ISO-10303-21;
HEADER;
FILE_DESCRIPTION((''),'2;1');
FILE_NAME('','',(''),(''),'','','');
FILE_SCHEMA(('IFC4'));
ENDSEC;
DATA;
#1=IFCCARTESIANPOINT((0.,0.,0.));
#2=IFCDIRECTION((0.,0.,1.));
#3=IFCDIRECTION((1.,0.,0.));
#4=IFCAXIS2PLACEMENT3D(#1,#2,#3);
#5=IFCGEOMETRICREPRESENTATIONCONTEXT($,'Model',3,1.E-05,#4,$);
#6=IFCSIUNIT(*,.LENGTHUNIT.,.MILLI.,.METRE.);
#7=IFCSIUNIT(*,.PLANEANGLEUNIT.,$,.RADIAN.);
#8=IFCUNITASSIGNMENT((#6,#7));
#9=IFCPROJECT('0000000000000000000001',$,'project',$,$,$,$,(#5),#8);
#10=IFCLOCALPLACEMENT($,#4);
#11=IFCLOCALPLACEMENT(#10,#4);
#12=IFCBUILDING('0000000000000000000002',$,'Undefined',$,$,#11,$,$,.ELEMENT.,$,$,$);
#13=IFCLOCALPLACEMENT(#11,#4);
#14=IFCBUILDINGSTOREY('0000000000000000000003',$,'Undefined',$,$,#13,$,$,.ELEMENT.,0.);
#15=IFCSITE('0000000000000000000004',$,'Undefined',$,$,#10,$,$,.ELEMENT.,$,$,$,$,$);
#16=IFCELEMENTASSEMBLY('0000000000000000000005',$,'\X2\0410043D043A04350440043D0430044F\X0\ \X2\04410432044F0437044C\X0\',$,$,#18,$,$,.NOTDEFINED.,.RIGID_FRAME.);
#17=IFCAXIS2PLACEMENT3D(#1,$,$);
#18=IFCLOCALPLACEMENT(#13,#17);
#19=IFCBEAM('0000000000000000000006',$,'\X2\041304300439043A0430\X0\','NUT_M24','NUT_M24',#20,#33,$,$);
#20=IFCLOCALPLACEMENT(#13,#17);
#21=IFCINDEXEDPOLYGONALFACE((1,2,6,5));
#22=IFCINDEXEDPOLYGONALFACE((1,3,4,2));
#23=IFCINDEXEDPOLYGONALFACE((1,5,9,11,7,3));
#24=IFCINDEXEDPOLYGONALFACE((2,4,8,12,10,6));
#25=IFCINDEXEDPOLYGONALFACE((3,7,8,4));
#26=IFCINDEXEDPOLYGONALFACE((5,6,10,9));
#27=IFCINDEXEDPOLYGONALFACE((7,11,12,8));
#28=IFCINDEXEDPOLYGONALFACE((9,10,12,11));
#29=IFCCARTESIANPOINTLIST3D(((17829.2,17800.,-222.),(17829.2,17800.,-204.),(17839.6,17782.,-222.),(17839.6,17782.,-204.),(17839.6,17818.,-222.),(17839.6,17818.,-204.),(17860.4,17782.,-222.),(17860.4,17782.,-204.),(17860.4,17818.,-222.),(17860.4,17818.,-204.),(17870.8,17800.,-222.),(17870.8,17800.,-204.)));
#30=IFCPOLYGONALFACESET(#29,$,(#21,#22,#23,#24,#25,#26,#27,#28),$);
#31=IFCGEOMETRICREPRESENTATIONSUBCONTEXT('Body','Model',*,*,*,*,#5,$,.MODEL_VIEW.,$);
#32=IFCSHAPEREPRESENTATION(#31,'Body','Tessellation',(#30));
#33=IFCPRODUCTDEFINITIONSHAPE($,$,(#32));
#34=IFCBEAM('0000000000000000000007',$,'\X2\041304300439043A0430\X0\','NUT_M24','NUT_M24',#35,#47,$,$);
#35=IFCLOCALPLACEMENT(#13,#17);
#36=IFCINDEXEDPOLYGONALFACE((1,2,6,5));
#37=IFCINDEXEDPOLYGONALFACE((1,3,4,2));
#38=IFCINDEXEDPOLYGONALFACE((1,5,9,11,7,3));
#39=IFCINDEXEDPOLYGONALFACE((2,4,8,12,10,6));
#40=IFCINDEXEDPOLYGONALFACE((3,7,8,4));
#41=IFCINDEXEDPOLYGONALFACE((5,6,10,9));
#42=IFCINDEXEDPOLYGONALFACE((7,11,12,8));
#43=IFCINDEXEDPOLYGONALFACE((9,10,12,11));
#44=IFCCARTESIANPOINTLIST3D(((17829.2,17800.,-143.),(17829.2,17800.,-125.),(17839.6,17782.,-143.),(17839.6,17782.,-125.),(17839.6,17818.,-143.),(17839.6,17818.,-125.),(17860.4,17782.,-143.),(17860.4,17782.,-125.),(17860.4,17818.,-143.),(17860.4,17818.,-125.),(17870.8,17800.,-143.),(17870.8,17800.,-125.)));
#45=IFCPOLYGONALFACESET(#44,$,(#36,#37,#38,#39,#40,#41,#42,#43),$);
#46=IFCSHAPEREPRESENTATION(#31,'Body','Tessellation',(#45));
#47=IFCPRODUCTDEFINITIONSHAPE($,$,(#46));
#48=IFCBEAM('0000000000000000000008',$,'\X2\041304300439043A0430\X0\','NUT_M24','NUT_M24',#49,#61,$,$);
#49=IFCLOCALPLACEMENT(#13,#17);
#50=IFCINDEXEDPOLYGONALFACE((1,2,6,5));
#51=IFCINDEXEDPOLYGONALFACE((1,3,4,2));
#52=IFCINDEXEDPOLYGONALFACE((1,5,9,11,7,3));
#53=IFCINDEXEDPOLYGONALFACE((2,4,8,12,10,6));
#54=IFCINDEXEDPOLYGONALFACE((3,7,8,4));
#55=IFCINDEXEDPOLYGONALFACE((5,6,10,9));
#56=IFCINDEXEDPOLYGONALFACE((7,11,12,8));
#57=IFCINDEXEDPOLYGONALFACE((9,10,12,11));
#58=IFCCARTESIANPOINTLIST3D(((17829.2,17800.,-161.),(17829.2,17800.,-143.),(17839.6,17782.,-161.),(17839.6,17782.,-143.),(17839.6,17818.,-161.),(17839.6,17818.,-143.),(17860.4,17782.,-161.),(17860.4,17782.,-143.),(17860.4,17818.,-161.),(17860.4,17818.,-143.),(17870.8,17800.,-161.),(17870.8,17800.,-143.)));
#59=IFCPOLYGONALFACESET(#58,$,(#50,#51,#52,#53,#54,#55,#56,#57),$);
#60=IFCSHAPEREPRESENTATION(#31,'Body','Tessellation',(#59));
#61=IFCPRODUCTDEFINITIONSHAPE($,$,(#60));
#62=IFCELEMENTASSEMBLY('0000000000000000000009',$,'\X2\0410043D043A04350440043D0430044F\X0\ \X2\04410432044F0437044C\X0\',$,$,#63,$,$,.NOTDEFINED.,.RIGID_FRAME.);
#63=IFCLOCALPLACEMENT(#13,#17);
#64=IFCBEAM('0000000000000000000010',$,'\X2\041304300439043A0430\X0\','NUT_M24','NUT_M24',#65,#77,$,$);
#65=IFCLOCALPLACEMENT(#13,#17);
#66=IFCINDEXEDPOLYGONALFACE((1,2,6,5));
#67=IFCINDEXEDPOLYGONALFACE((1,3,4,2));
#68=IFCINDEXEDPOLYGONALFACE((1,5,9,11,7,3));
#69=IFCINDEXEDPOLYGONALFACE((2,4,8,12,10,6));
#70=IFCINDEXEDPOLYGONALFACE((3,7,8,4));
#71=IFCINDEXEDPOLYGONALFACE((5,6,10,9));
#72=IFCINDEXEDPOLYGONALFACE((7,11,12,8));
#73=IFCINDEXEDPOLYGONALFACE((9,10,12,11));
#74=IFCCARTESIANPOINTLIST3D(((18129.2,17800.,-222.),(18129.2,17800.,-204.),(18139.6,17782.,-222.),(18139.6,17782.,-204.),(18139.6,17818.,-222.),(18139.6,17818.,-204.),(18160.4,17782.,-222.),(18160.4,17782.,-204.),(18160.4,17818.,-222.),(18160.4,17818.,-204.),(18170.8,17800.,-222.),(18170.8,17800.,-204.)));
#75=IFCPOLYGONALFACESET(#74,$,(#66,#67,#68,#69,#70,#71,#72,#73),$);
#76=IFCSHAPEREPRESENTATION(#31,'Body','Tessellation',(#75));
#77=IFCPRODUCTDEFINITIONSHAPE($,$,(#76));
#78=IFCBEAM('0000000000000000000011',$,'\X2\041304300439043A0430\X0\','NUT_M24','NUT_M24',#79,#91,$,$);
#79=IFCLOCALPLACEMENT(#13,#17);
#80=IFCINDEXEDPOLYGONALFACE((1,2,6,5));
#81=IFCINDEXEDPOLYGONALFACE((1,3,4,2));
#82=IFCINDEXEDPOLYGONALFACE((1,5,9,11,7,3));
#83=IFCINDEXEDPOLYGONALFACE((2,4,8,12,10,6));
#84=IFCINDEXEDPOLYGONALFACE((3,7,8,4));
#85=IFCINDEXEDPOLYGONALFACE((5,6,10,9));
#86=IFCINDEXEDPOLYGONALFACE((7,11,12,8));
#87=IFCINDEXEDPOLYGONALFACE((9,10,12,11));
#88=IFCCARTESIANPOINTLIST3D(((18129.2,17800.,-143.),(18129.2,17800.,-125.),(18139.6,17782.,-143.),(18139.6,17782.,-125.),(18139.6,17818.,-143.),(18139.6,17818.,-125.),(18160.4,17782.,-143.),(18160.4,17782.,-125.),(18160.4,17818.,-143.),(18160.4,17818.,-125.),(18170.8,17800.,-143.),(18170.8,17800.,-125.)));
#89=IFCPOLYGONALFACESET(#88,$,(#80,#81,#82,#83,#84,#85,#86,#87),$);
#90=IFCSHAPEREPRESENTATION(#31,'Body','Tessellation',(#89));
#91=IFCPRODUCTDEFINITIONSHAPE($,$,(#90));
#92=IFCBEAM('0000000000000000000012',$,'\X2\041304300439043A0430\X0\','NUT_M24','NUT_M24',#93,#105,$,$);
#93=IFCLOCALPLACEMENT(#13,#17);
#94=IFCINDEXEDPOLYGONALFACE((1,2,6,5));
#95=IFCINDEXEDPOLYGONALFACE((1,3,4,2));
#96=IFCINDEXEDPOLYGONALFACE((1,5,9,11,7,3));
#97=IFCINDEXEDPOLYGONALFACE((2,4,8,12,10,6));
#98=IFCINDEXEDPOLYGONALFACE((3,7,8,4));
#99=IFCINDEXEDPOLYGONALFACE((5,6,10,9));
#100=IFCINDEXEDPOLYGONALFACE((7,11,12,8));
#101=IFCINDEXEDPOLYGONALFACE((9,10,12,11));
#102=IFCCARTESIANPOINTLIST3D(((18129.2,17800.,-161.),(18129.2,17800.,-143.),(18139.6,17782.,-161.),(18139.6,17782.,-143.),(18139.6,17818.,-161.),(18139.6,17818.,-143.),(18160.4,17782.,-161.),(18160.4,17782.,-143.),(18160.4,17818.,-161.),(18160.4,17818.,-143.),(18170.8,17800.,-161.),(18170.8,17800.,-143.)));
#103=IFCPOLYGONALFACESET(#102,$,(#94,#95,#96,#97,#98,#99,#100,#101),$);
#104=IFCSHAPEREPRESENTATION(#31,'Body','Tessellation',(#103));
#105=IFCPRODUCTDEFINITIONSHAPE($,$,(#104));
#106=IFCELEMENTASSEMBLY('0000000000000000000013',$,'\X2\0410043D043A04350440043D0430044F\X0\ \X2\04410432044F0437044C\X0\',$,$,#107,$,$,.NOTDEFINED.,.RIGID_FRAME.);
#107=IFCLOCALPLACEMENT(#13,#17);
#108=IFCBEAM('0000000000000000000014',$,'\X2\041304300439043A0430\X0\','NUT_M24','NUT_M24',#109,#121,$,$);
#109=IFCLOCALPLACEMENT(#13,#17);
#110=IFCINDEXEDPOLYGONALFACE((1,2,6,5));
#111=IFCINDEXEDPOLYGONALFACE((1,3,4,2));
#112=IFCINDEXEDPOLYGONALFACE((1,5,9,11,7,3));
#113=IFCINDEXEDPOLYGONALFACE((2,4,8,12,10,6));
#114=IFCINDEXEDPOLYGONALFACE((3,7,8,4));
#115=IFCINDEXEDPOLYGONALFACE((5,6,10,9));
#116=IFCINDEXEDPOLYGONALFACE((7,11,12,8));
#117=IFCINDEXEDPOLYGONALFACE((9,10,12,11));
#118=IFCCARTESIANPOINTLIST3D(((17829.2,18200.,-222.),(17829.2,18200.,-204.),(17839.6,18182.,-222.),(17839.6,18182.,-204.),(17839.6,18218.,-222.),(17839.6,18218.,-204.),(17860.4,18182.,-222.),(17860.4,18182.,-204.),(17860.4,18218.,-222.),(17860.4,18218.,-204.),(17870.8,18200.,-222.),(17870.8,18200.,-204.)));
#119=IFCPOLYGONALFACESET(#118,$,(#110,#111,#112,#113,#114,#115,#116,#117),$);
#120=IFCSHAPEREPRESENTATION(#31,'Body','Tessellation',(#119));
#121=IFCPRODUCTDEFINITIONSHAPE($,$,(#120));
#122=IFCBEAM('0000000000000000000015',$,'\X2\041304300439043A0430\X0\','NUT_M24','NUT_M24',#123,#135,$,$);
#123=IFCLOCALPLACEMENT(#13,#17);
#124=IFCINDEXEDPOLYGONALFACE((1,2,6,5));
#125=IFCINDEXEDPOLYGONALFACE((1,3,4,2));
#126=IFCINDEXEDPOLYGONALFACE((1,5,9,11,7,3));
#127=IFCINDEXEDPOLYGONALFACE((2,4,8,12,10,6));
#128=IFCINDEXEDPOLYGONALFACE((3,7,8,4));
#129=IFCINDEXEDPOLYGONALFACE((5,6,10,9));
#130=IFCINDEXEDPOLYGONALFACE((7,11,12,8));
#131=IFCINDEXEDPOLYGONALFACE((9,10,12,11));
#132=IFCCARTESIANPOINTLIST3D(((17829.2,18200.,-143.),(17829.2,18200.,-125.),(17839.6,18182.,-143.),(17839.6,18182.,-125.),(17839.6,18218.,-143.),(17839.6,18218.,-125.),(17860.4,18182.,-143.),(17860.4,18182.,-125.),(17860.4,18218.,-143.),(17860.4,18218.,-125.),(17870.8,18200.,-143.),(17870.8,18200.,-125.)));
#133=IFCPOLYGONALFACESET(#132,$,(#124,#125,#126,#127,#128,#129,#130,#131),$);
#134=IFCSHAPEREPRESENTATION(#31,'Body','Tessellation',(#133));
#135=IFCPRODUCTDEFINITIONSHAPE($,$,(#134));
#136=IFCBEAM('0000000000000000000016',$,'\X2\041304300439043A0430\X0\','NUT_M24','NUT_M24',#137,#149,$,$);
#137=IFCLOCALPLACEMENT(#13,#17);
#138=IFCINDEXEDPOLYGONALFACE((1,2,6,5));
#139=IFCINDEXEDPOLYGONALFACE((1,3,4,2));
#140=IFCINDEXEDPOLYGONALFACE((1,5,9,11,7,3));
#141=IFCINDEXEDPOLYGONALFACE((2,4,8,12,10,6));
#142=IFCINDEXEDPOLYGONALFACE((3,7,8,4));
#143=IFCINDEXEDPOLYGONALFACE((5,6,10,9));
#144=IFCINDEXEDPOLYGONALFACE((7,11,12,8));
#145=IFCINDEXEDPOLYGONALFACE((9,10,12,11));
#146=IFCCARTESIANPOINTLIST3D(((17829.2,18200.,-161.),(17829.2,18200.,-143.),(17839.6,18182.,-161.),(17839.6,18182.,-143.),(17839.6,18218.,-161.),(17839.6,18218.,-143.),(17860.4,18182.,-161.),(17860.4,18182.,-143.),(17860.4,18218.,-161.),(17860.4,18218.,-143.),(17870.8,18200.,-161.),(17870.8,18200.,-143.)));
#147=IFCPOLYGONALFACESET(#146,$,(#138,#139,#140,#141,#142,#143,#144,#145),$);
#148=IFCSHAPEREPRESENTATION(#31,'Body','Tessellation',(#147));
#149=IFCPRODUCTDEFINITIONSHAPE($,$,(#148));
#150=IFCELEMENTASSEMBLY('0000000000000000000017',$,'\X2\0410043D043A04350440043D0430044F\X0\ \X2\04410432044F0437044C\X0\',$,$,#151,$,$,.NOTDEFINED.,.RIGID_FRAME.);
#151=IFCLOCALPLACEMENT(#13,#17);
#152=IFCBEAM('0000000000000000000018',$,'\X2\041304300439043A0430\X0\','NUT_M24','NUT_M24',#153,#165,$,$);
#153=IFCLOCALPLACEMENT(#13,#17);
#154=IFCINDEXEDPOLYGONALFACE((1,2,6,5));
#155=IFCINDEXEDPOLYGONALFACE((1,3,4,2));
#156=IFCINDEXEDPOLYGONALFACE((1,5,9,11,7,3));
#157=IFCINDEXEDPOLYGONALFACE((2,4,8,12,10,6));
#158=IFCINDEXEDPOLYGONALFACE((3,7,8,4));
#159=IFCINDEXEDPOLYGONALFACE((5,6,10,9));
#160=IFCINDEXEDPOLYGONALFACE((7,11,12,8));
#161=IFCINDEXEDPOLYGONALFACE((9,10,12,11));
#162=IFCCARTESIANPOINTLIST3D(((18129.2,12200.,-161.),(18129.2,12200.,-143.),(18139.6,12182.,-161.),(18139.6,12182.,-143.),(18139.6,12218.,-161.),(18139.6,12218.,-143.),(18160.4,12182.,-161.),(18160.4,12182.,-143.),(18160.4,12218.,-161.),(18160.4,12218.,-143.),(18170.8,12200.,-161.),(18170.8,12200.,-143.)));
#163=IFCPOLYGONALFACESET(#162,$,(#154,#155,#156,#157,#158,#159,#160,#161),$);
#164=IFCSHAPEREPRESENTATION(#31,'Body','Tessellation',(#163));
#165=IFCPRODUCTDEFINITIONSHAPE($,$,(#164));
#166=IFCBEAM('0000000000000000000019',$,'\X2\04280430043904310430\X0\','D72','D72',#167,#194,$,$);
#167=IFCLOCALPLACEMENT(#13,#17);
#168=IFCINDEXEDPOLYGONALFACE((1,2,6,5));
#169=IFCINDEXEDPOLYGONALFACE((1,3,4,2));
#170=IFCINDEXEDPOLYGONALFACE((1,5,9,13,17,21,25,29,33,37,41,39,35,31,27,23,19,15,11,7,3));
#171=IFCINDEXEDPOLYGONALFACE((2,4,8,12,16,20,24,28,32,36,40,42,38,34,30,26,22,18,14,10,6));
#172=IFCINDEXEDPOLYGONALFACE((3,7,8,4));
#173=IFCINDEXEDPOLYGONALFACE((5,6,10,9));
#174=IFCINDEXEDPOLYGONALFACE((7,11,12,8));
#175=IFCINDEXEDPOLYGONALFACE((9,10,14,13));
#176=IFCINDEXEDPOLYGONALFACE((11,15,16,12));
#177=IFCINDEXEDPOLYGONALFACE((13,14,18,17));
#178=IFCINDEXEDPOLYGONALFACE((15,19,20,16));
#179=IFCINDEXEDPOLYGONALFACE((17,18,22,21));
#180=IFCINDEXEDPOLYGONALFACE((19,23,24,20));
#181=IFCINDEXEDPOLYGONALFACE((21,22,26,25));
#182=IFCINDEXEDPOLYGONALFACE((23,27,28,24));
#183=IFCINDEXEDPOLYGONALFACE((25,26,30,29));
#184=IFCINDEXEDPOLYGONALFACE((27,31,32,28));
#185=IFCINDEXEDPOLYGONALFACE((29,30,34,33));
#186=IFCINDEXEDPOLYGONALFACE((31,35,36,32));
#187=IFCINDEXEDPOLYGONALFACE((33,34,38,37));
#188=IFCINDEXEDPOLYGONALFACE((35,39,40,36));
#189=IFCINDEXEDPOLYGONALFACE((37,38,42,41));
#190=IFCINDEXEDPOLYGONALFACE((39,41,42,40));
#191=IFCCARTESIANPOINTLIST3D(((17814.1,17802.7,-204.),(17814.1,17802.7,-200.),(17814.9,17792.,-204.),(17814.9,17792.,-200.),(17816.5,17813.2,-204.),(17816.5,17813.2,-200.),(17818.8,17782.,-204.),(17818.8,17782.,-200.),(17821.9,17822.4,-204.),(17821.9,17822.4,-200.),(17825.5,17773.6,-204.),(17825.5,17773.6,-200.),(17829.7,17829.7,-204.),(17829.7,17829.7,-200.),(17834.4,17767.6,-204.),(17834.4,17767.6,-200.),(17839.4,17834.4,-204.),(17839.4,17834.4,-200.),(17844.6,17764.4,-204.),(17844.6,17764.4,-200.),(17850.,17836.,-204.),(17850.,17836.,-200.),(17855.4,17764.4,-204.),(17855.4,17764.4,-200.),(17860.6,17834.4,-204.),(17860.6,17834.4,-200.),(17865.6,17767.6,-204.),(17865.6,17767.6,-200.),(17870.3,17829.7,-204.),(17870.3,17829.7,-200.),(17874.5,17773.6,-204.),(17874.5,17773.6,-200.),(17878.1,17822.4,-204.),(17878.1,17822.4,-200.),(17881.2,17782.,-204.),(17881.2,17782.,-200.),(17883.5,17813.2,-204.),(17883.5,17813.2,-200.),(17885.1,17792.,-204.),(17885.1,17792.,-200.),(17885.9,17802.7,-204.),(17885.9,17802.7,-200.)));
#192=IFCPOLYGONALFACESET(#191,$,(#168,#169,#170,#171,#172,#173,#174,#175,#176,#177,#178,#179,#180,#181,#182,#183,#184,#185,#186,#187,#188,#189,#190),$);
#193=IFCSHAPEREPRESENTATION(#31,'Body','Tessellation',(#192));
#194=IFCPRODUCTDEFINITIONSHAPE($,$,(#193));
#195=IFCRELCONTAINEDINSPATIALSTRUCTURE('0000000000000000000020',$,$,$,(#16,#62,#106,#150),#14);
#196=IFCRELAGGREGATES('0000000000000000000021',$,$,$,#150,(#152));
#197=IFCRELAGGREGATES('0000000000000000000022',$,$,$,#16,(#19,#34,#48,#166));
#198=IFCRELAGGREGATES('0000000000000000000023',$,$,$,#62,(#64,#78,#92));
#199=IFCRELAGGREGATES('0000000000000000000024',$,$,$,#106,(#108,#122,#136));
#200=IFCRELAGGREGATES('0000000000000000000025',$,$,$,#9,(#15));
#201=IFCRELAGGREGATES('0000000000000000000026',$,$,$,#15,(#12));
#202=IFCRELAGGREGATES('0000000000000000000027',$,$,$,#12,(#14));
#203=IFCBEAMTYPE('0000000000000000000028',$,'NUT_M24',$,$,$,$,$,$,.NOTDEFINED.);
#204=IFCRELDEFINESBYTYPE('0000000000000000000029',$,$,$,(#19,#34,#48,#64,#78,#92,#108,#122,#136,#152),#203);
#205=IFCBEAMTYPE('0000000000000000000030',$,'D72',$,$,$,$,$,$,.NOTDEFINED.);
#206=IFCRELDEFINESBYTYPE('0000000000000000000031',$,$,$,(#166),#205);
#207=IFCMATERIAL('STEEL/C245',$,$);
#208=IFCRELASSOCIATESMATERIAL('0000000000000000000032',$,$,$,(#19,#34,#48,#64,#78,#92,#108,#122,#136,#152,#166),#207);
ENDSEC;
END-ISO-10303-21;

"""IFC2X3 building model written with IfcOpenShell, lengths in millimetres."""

from ifc_helpers import new_model, si_unit, frame, origin_with_axes, origin_2d_with_axis, place, context, subcontext, project, spatial, polyline, circle, outline, extrude, material, type_object, element, aggregate, save


model = new_model("IFC2X3")

# Units and contexts
model_context = context("Model", 3, precision=1e-05, world=origin_with_axes())
body_context = subcontext(model_context, "Body", "Model", "MODEL_VIEW")
ifc_project = project(units=[si_unit("LENGTHUNIT", "METRE", prefix="MILLI"), si_unit("PLANEANGLEUNIT", "RADIAN")], contexts=[model_context])

# Site, building, storey
site_placement = place(None, origin_with_axes())
site = spatial("IfcSite", under=ifc_project, at=site_placement, Name="Undefined", CompositionType="ELEMENT")
building_placement = place(site_placement, origin_with_axes())
building = spatial("IfcBuilding", under=site, at=building_placement, Name="Undefined", CompositionType="ELEMENT")
storey_placement = place(building_placement, origin_with_axes())
storey = spatial("IfcBuildingStorey", under=building, at=storey_placement, Name="Undefined", CompositionType="ELEMENT", Elevation=0.0)

# Element assemblies, beams
assembly_1_placement = place(storey_placement, origin_with_axes())
assembly_1 = element("IfcElementAssembly", 1, at=assembly_1_placement, inside=storey, Name="Анкерная связь", AssemblyPlace="NOTDEFINED", PredefinedType="RIGID_FRAME")
ifc_material_1 = material(Name="STEEL/C245")
beam_type_1 = type_object("IfcBeamType", Name="NUT_M24", PredefinedType="NOTDEFINED")
beam_1_placement = place(assembly_1_placement, frame((17850.0, 17800.0, -204.0), z_axis=(0.0, -1.0, 0.0), x_axis=(0.0, 0.0, -1.0)))
beam_1 = element("IfcBeam", 2, at=beam_1_placement, type_object=beam_type_1, material=ifc_material_1, Name="Гайка", Description="NUT_M24", ObjectType="NUT_M24", context=body_context, shape_type="SweptSolid", body=[
    extrude(outline(polyline([(-10.4, 18.0), (10.4, 18.0), (20.8, 0.0), (10.4, -18.0), (-10.4, -18.0), (-20.8, 0.0), (-10.4, 18.0)])), frame((18.0, 0.0, 0.0), z_axis=(-1.0, 0.0, 0.0), x_axis=(0.0, -1.0, 0.0)), (0.0, 0.0, 1.0), 18.0),
])
beam_2_placement = place(assembly_1_placement, frame((17850.0, 17800.0, -125.0), z_axis=(0.0, -1.0, 0.0), x_axis=(0.0, 0.0, -1.0)))
beam_2 = element("IfcBeam", 3, at=beam_2_placement, type_object=beam_type_1, material=ifc_material_1, Name="Гайка", Description="NUT_M24", ObjectType="NUT_M24", context=body_context, shape_type="SweptSolid", body=[
    extrude(outline(polyline([(-10.4, 18.0), (10.4, 18.0), (20.8, 0.0), (10.4, -18.0), (-10.4, -18.0), (-20.8, 0.0), (-10.4, 18.0)])), frame((18.0, 0.0, 0.0), z_axis=(-1.0, 0.0, 0.0), x_axis=(0.0, -1.0, 0.0)), (0.0, 0.0, 1.0), 18.0),
])
beam_3_placement = place(assembly_1_placement, frame((17850.0, 17800.0, -143.0), z_axis=(0.0, -1.0, 0.0), x_axis=(0.0, 0.0, -1.0)))
beam_3 = element("IfcBeam", 4, at=beam_3_placement, type_object=beam_type_1, material=ifc_material_1, Name="Гайка", Description="NUT_M24", ObjectType="NUT_M24", context=body_context, shape_type="SweptSolid", body=[
    extrude(outline(polyline([(-10.4, 18.0), (10.4, 18.0), (20.8, 0.0), (10.4, -18.0), (-10.4, -18.0), (-20.8, 0.0), (-10.4, 18.0)])), frame((18.0, 0.0, 0.0), z_axis=(-1.0, 0.0, 0.0), x_axis=(0.0, -1.0, 0.0)), (0.0, 0.0, 1.0), 18.0),
])
assembly_2_placement = place(storey_placement, origin_with_axes())
assembly_2 = element("IfcElementAssembly", 5, at=assembly_2_placement, inside=storey, Name="Анкерная связь", AssemblyPlace="NOTDEFINED", PredefinedType="RIGID_FRAME")
beam_4_placement = place(assembly_2_placement, frame((18150.0, 17800.0, -204.0), z_axis=(0.0, 1.0, 0.0), x_axis=(0.0, 0.0, -1.0)))
beam_4 = element("IfcBeam", 6, at=beam_4_placement, type_object=beam_type_1, material=ifc_material_1, Name="Гайка", Description="NUT_M24", ObjectType="NUT_M24", context=body_context, shape_type="SweptSolid", body=[
    extrude(outline(polyline([(-10.4, 18.0), (10.4, 18.0), (20.8, 0.0), (10.4, -18.0), (-10.4, -18.0), (-20.8, 0.0), (-10.4, 18.0)])), frame((18.0, 0.0, 0.0), z_axis=(-1.0, 0.0, 0.0), x_axis=(0.0, -1.0, 0.0)), (0.0, 0.0, 1.0), 18.0),
])
beam_5_placement = place(assembly_2_placement, frame((18150.0, 17800.0, -125.0), z_axis=(0.0, 1.0, 0.0), x_axis=(0.0, 0.0, -1.0)))
beam_5 = element("IfcBeam", 7, at=beam_5_placement, type_object=beam_type_1, material=ifc_material_1, Name="Гайка", Description="NUT_M24", ObjectType="NUT_M24", context=body_context, shape_type="SweptSolid", body=[
    extrude(outline(polyline([(-10.4, 18.0), (10.4, 18.0), (20.8, 0.0), (10.4, -18.0), (-10.4, -18.0), (-20.8, 0.0), (-10.4, 18.0)])), frame((18.0, 0.0, 0.0), z_axis=(-1.0, 0.0, 0.0), x_axis=(0.0, -1.0, 0.0)), (0.0, 0.0, 1.0), 18.0),
])
beam_6_placement = place(assembly_2_placement, frame((18150.0, 17800.0, -143.0), z_axis=(0.0, 1.0, 0.0), x_axis=(0.0, 0.0, -1.0)))
beam_6 = element("IfcBeam", 8, at=beam_6_placement, type_object=beam_type_1, material=ifc_material_1, Name="Гайка", Description="NUT_M24", ObjectType="NUT_M24", context=body_context, shape_type="SweptSolid", body=[
    extrude(outline(polyline([(-10.4, 18.0), (10.4, 18.0), (20.8, 0.0), (10.4, -18.0), (-10.4, -18.0), (-20.8, 0.0), (-10.4, 18.0)])), frame((18.0, 0.0, 0.0), z_axis=(-1.0, 0.0, 0.0), x_axis=(0.0, -1.0, 0.0)), (0.0, 0.0, 1.0), 18.0),
])
assembly_3_placement = place(storey_placement, origin_with_axes())
assembly_3 = element("IfcElementAssembly", 9, at=assembly_3_placement, inside=storey, Name="Анкерная связь", AssemblyPlace="NOTDEFINED", PredefinedType="RIGID_FRAME")
beam_7_placement = place(assembly_3_placement, frame((17850.0, 18200.0, -204.0), z_axis=(0.0, -1.0, 0.0), x_axis=(0.0, 0.0, -1.0)))
beam_7 = element("IfcBeam", 10, at=beam_7_placement, type_object=beam_type_1, material=ifc_material_1, Name="Гайка", Description="NUT_M24", ObjectType="NUT_M24", context=body_context, shape_type="SweptSolid", body=[
    extrude(outline(polyline([(-10.4, 18.0), (10.4, 18.0), (20.8, 0.0), (10.4, -18.0), (-10.4, -18.0), (-20.8, 0.0), (-10.4, 18.0)])), frame((18.0, 0.0, 0.0), z_axis=(-1.0, 0.0, 0.0), x_axis=(0.0, -1.0, 0.0)), (0.0, 0.0, 1.0), 18.0),
])
beam_8_placement = place(assembly_3_placement, frame((17850.0, 18200.0, -125.0), z_axis=(0.0, -1.0, 0.0), x_axis=(0.0, 0.0, -1.0)))
beam_8 = element("IfcBeam", 11, at=beam_8_placement, type_object=beam_type_1, material=ifc_material_1, Name="Гайка", Description="NUT_M24", ObjectType="NUT_M24", context=body_context, shape_type="SweptSolid", body=[
    extrude(outline(polyline([(-10.4, 18.0), (10.4, 18.0), (20.8, 0.0), (10.4, -18.0), (-10.4, -18.0), (-20.8, 0.0), (-10.4, 18.0)])), frame((18.0, 0.0, 0.0), z_axis=(-1.0, 0.0, 0.0), x_axis=(0.0, -1.0, 0.0)), (0.0, 0.0, 1.0), 18.0),
])
beam_9_placement = place(assembly_3_placement, frame((17850.0, 18200.0, -143.0), z_axis=(0.0, -1.0, 0.0), x_axis=(0.0, 0.0, -1.0)))
beam_9 = element("IfcBeam", 12, at=beam_9_placement, type_object=beam_type_1, material=ifc_material_1, Name="Гайка", Description="NUT_M24", ObjectType="NUT_M24", context=body_context, shape_type="SweptSolid", body=[
    extrude(outline(polyline([(-10.4, 18.0), (10.4, 18.0), (20.8, 0.0), (10.4, -18.0), (-10.4, -18.0), (-20.8, 0.0), (-10.4, 18.0)])), frame((18.0, 0.0, 0.0), z_axis=(-1.0, 0.0, 0.0), x_axis=(0.0, -1.0, 0.0)), (0.0, 0.0, 1.0), 18.0),
])

# Element assembly, beam
assembly_4_placement = place(storey_placement, origin_with_axes())
assembly_4 = element("IfcElementAssembly", 13, at=assembly_4_placement, inside=storey, Name="Анкерная связь", AssemblyPlace="NOTDEFINED", PredefinedType="RIGID_FRAME")
beam_10_placement = place(assembly_4_placement, frame((18150.0, 12200.0, -143.0), z_axis=(0.0, 1.0, 0.0), x_axis=(0.0, 0.0, -1.0)))
beam_10 = element("IfcBeam", 14, at=beam_10_placement, type_object=beam_type_1, material=ifc_material_1, Name="Гайка", Description="NUT_M24", ObjectType="NUT_M24", context=body_context, shape_type="SweptSolid", body=[
    extrude(outline(polyline([(-10.4, 18.0), (10.4, 18.0), (20.8, 0.0), (10.4, -18.0), (-10.4, -18.0), (-20.8, 0.0), (-10.4, 18.0)])), frame((18.0, 0.0, 0.0), z_axis=(-1.0, 0.0, 0.0), x_axis=(0.0, -1.0, 0.0)), (0.0, 0.0, 1.0), 18.0),
])

# Beam
beam_type_2 = type_object("IfcBeamType", Name="D72", PredefinedType="NOTDEFINED")
beam_11_placement = place(assembly_1_placement, frame((17850.0, 17800.0, -200.0), z_axis=(-1.0, 0.0, 0.0), x_axis=(0.0, 0.0, -1.0)))
beam_11 = element("IfcBeam", 15, at=beam_11_placement, type_object=beam_type_2, material=ifc_material_1, Name="Шайба", Description="D72", ObjectType="D72", context=body_context, shape_type="SweptSolid", body=[
    extrude(circle(Radius=36.0, at=origin_2d_with_axis()), frame((4.0, 0.0, 0.0), z_axis=(-1.0, 0.0, 0.0), x_axis=(0.0, -1.0, 0.0)), (0.0, 0.0, 1.0), 4.0),
])

aggregate(assembly_4, [beam_10])

aggregate(assembly_1, [beam_1, beam_2, beam_3, beam_11])
aggregate(assembly_2, [beam_4, beam_5, beam_6])
aggregate(assembly_3, [beam_7, beam_8, beam_9])

save(model, "model.ifc")
